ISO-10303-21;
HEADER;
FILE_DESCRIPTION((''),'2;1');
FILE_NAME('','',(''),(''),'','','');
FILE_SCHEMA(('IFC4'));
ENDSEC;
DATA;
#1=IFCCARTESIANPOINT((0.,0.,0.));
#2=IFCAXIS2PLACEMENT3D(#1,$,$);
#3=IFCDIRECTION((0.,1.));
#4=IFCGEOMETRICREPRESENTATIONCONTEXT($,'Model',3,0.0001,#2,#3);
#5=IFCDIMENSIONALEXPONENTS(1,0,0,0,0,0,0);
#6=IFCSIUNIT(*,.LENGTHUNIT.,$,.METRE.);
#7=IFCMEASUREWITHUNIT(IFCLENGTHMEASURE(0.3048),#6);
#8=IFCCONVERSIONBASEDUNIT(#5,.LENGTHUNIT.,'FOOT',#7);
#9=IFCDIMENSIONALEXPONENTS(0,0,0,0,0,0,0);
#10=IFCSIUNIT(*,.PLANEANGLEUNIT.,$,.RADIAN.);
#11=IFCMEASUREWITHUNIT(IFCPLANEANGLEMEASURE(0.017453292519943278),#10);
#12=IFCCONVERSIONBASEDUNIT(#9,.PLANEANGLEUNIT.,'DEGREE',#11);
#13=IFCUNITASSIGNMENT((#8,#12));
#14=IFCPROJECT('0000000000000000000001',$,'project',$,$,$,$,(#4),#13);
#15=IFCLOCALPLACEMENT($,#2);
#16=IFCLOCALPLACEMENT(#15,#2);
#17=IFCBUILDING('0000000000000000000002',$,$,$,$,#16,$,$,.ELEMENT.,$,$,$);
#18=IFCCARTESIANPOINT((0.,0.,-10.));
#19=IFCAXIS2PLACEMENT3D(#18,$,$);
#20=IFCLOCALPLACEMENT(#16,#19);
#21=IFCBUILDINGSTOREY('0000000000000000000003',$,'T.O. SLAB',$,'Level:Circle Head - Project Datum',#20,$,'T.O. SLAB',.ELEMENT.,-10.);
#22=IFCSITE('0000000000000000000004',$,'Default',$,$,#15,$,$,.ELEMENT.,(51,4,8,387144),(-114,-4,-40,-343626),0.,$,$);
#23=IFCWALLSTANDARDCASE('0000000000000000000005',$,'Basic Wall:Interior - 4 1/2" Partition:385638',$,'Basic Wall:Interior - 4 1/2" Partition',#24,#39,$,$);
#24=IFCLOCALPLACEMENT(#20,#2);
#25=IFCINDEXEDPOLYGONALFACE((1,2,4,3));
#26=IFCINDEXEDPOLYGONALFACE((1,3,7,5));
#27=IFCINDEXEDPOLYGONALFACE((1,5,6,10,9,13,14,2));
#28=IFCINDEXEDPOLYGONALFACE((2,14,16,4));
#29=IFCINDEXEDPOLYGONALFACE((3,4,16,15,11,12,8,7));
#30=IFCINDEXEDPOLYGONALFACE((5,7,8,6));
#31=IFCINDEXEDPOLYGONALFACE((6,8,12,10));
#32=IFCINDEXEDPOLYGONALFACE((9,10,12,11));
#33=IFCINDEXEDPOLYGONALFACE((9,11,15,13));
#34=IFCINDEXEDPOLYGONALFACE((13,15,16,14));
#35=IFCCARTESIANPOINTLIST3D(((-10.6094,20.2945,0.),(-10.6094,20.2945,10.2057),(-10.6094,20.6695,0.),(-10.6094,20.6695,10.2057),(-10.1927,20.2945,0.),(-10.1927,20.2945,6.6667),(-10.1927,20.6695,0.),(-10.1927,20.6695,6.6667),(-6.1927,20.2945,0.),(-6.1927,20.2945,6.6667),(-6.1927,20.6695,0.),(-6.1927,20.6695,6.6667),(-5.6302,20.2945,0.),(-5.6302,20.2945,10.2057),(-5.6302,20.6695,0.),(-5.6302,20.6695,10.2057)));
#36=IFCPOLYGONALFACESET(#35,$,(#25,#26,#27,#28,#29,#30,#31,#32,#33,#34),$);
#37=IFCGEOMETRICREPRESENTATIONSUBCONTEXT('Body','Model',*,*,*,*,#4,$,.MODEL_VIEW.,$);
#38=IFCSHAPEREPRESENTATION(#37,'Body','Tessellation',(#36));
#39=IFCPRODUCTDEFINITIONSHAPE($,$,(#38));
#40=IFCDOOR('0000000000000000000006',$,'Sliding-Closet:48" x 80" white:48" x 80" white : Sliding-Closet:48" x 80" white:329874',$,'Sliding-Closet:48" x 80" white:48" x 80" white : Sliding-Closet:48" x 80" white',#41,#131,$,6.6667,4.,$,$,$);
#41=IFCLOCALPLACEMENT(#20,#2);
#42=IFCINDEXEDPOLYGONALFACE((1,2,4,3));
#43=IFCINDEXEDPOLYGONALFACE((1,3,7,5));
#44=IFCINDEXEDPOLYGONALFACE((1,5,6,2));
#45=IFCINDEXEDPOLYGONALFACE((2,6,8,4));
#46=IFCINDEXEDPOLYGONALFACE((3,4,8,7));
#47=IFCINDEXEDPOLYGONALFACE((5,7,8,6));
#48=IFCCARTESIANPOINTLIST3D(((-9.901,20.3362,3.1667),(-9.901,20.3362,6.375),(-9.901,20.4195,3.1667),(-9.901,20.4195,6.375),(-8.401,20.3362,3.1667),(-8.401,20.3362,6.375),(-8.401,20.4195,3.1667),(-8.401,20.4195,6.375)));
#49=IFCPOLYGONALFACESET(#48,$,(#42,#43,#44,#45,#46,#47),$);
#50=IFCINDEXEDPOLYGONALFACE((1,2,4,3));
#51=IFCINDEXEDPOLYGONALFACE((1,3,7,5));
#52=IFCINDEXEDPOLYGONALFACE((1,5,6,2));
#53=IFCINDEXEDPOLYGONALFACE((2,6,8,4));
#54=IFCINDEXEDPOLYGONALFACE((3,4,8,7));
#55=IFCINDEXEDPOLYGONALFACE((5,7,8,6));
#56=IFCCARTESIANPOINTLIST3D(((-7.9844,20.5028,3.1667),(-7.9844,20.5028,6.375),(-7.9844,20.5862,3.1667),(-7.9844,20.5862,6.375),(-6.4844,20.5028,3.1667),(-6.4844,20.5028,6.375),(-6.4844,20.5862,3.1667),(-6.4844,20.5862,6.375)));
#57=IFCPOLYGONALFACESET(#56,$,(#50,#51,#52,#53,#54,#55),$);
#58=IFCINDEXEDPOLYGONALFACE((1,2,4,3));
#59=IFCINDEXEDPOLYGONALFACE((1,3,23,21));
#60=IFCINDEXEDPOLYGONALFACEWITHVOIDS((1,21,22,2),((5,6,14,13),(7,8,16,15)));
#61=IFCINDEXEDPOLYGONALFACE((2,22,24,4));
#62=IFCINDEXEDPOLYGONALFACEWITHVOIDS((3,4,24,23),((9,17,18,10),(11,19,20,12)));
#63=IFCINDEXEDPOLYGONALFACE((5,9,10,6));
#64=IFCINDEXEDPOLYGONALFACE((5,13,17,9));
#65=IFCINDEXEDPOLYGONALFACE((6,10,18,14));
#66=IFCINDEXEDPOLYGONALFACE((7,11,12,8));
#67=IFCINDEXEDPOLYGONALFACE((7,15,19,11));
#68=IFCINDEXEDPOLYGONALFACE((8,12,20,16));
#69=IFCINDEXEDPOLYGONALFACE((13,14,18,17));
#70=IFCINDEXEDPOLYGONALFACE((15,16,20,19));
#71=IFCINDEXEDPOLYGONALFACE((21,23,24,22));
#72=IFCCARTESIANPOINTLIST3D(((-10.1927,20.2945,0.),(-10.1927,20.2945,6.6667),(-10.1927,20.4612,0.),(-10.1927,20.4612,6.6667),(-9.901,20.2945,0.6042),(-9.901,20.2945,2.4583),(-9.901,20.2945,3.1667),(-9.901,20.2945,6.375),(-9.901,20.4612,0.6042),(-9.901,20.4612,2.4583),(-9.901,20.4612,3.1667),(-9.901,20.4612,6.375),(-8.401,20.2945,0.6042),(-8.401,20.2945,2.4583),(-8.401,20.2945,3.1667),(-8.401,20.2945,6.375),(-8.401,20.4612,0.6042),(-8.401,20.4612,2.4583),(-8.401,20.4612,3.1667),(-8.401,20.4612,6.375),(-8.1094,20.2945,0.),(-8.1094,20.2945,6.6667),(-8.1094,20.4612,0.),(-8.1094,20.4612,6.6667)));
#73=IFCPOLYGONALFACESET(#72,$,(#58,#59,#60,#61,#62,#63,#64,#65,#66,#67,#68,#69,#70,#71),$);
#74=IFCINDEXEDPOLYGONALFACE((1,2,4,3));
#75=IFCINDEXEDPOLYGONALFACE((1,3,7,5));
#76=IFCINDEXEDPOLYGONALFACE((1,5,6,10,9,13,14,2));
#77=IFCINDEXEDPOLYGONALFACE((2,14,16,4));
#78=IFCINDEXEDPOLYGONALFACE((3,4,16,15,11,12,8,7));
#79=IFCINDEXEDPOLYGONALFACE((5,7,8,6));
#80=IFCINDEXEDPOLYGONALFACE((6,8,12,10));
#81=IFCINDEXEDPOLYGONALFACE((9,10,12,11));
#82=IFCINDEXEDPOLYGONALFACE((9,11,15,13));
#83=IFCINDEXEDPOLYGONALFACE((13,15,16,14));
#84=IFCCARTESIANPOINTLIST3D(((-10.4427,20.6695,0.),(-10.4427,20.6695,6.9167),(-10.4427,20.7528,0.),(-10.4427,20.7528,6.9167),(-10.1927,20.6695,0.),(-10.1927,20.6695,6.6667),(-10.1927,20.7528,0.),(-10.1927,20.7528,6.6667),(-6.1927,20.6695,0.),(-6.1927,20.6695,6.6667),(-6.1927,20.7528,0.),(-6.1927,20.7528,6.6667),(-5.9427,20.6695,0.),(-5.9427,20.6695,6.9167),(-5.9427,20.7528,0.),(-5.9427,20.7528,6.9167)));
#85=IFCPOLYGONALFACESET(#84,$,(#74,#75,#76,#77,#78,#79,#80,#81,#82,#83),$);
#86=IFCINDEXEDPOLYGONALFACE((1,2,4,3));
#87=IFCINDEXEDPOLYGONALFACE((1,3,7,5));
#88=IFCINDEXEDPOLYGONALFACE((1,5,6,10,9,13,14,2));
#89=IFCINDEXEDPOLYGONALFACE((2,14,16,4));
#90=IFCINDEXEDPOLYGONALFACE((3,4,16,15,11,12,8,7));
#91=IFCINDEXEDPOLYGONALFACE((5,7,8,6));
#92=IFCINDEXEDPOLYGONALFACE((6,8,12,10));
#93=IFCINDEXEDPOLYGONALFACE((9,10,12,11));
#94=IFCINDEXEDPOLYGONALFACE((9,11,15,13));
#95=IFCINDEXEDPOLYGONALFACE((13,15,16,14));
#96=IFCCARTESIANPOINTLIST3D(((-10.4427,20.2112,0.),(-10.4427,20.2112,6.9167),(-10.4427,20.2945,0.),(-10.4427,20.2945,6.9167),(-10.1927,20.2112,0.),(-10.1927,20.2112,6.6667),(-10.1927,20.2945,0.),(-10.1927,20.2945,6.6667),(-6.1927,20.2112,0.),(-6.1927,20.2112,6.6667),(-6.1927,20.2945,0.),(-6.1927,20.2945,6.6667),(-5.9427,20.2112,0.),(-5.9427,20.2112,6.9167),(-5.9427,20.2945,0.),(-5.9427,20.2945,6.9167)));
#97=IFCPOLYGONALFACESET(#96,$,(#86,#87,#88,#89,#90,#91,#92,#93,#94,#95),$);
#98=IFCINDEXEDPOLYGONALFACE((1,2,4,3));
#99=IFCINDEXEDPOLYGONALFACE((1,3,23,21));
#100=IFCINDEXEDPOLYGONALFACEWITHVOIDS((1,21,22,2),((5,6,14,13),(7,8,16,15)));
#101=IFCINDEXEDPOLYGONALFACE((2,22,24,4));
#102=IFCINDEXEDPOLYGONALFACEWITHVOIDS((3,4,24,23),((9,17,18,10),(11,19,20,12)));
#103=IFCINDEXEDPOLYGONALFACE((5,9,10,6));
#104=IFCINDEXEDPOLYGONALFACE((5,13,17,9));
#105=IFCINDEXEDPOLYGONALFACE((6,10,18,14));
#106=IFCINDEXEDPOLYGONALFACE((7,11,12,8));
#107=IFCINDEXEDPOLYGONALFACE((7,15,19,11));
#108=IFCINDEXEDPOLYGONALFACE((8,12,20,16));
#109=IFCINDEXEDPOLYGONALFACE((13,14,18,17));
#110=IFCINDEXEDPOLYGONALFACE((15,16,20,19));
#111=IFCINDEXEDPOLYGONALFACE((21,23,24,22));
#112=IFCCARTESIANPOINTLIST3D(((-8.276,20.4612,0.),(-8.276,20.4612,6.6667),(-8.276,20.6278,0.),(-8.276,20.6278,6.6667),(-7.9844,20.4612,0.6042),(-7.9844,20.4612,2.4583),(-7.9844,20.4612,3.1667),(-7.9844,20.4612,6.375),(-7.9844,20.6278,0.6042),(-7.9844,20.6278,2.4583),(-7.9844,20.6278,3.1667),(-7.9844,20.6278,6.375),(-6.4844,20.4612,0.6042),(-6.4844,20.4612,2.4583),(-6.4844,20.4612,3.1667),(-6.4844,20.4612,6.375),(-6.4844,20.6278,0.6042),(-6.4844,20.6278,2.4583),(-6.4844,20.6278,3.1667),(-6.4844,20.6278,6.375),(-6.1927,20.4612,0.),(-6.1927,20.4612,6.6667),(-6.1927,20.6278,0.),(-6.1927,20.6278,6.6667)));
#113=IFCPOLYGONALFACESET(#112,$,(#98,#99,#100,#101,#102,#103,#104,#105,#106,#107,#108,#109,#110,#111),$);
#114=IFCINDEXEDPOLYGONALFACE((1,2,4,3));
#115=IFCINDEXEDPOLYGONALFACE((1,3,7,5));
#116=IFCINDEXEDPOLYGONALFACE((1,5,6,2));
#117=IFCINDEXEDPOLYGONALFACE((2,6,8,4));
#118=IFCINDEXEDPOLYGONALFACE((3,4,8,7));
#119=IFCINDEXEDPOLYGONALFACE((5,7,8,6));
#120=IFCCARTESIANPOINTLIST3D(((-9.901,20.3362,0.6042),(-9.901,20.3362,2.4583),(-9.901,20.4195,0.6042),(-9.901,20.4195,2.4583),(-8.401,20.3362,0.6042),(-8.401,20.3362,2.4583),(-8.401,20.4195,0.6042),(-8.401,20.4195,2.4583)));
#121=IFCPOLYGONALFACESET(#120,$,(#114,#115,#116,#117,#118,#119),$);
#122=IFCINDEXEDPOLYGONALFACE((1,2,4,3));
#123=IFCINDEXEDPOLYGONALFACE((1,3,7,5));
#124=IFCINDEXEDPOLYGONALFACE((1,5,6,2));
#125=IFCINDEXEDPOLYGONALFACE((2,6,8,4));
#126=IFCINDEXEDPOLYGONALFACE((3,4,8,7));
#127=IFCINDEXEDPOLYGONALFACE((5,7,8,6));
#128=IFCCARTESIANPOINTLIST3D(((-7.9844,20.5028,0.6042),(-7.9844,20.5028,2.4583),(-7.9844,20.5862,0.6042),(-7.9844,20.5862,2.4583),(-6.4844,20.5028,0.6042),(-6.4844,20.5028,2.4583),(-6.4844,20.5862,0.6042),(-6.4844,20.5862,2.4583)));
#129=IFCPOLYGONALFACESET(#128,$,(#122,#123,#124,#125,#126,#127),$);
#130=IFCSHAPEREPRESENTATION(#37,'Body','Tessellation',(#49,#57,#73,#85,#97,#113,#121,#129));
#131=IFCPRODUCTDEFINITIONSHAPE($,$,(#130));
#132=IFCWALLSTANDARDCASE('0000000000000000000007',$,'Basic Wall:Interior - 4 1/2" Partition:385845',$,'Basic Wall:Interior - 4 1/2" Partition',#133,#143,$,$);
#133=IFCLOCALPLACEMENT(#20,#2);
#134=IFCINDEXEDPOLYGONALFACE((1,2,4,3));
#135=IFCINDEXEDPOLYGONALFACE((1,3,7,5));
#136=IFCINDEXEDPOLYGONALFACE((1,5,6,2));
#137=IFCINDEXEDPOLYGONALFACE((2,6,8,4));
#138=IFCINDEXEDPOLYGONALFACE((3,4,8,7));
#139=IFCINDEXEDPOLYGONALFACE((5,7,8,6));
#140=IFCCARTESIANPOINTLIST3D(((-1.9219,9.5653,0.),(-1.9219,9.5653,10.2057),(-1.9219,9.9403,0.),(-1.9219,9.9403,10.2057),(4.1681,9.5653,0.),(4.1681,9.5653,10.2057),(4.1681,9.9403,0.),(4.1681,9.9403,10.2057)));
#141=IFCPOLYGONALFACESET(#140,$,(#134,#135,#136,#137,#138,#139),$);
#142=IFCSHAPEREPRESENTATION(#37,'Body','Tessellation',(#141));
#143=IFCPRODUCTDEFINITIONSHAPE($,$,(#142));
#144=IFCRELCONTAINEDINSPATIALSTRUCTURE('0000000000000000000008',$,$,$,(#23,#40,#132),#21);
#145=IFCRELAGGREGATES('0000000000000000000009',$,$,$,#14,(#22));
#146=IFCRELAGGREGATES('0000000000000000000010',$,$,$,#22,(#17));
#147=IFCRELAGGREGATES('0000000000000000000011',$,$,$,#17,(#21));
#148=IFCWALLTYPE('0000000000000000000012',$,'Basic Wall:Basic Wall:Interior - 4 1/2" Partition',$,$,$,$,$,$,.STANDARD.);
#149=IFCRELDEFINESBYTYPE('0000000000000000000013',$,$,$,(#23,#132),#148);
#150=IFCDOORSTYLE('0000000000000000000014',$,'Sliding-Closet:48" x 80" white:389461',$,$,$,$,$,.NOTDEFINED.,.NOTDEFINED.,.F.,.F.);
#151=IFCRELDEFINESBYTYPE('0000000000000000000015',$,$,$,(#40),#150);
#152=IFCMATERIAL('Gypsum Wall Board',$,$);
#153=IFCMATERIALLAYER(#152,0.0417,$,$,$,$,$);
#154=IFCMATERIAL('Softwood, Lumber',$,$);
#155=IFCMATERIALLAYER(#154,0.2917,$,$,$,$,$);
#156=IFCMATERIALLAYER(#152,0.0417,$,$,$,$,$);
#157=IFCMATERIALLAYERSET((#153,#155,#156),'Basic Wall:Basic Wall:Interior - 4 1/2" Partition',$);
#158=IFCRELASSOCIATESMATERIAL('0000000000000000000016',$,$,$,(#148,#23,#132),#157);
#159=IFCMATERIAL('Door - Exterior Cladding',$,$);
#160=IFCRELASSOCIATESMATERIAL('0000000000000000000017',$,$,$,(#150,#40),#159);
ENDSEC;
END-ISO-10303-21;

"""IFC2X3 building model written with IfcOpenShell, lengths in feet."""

from ifc_helpers import new_model, entity, si_unit, converted_unit, direction, frame, frame_2d, origin, origin_2d_with_axis, place, context, subcontext, project, spatial, polyline, rectangle, outline, extrude, source, transform, mapped, material, layer, layer_set, layer_usage, type_object, type_shapes, element, fill, save


model = new_model("IFC2X3")

# Units and contexts
model_context = context("Model", 3, precision=0.0001, world=origin(), true_north=direction((0.0, 1.0)))
body_context = subcontext(model_context, "Body", "Model", "MODEL_VIEW")
ifc_project = project(units=[converted_unit("LENGTHUNIT", "FOOT", entity("IfcLengthMeasure", 0.3048), si_unit("LENGTHUNIT", "METRE"), dimensions=[1, 0, 0, 0, 0, 0, 0]), converted_unit("PLANEANGLEUNIT", "DEGREE", entity("IfcPlaneAngleMeasure", 0.017453292519943278), si_unit("PLANEANGLEUNIT", "RADIAN"), dimensions=[0, 0, 0, 0, 0, 0, 0])], contexts=[model_context])

# Site, building, storey
site_placement = place(None, origin())
site = spatial("IfcSite", under=ifc_project, at=site_placement, Name="Default", CompositionType="ELEMENT", RefLatitude=(51, 4, 8, 387144), RefLongitude=(-114, -4, -40, -343626), RefElevation=0.0)
building_placement = place(site_placement, origin())
building = spatial("IfcBuilding", under=site, at=building_placement, CompositionType="ELEMENT")
storey_placement = place(building_placement, frame((0.0, 0.0, -10.0)))
storey = spatial("IfcBuildingStorey", under=building, at=storey_placement, Name="T.O. SLAB", ObjectType="Level:Circle Head - Project Datum", LongName="T.O. SLAB", CompositionType="ELEMENT", Elevation=-10.0)

# Shared definitions
ifc_material_1 = material(Name="Gypsum Wall Board")
ifc_layer_1 = layer(ifc_material_1, 0.0417)
ifc_material_2 = material(Name="Softwood, Lumber")
ifc_layer_2 = layer(ifc_material_2, 0.2917)
ifc_layer_3 = layer(ifc_material_1, 0.0417)
ifc_layer_set_1 = layer_set([ifc_layer_1, ifc_layer_2, ifc_layer_3], Name="Basic Wall:Basic Wall:Interior - 4 1/2\" Partition")
wall_type_1 = type_object("IfcWallType", Name="Basic Wall:Basic Wall:Interior - 4 1/2\" Partition", PredefinedType="STANDARD", material=ifc_layer_set_1)
ifc_material_3 = material(Name="Door - Exterior Cladding")

# Wall, opening, door
ifc_layer_usage_1 = layer_usage(ifc_layer_set_1, "AXIS2", "NEGATIVE", 0.1875)
wall_1_placement = place(storey_placement, frame((-10.6094, 20.482, 0.0)))
wall_1 = element("IfcWallStandardCase", 1, at=wall_1_placement, inside=storey, type_object=wall_type_1, material=ifc_layer_usage_1, Name="Basic Wall:Interior - 4 1/2\" Partition:385638", ObjectType="Basic Wall:Interior - 4 1/2\" Partition", context=body_context, shape_type="SweptSolid", body=[
    extrude(rectangle(XDim=4.9792, YDim=0.375, at=frame_2d((2.4896, 0.0), x_axis=(1.0, 0.0))), origin(), (0.0, 0.0, 1.0), 10.2057),
])
opening_1_placement = place(wall_1_placement, frame((10.6094, -20.482, 0.0)))
opening_1 = element("IfcOpeningElement", 2, at=opening_1_placement, cuts=wall_1, ObjectType="Opening", context=body_context, shape_type="SweptSolid", body=[
    extrude(rectangle(XDim=6.6667, YDim=4.0, at=origin_2d_with_axis()), frame((-8.1927, 20.2908, 3.3333), z_axis=(0.0, 1.0, 0.0), x_axis=(0.0, 0.0, 1.0)), (0.0, 0.0, 1.0), 0.3825),
])
door_style_1 = type_object("IfcDoorStyle", Name="Sliding-Closet:48\" x 80\" white:389461", ConstructionType="NOTDEFINED", OperationType="NOTDEFINED", ParameterTakesPrecedence=False, Sizeable=False, material=ifc_material_3)
shared_shape_1 = source(origin(), body_context, "Body", "SweptSolid", [
    extrude(rectangle(XDim=0.0833, YDim=1.5, at=origin_2d_with_axis()), frame((2.9583, 0.2954, 3.1667), z_axis=(0.0, 0.0, 1.0), x_axis=(0.0, 1.0, 0.0)), (0.0, 0.0, 1.0), 3.2083),
    extrude(rectangle(XDim=0.0833, YDim=1.5, at=origin_2d_with_axis()), frame((1.0417, 0.1287, 3.1667), z_axis=(0.0, 0.0, 1.0), x_axis=(0.0, -1.0, 0.0)), (0.0, 0.0, 1.0), 3.2083),
    extrude(outline(polyline([(-3.3333, -1.0417), (3.3333, -1.0417), (3.3333, 1.0417), (-3.3333, 1.0417), (-3.3333, -1.0417)]), holes=[polyline([(-0.1667, -0.75), (-0.1667, 0.75), (3.0417, 0.75), (3.0417, -0.75), (-0.1667, -0.75)]), polyline([(-2.7292, -0.75), (-2.7292, 0.75), (-0.875, 0.75), (-0.875, -0.75), (-2.7292, -0.75)])]), frame((2.9583, 0.2121, 3.3333), z_axis=(0.0, 1.0, 0.0), x_axis=(0.0, 0.0, 1.0)), (0.0, 0.0, 1.0), 0.1667),
    extrude(outline(polyline([(-3.5208, -2.25), (3.3958, -2.25), (3.3958, -2.0), (-3.2708, -2.0), (-3.2708, 2.0), (3.3958, 2.0), (3.3958, 2.25), (-3.5208, 2.25), (-3.5208, -2.25)])), frame((2.0, -0.0796, 3.3958), z_axis=(0.0, 1.0, 0.0), x_axis=(0.0, 0.0, -1.0)), (0.0, 0.0, 1.0), 0.0833),
    extrude(outline(polyline([(2.0, -3.3958), (2.25, -3.3958), (2.25, 3.5208), (-2.25, 3.5208), (-2.25, -3.3958), (-2.0, -3.3958), (-2.0, 3.2708), (2.0, 3.2708), (2.0, -3.3958)])), frame((2.0, 0.3788, 3.3958), z_axis=(0.0, 1.0, 0.0), x_axis=(-1.0, 0.0, 0.0)), (0.0, 0.0, 1.0), 0.0833),
    extrude(outline(polyline([(-1.0417, -3.3333), (1.0417, -3.3333), (1.0417, 3.3333), (-1.0417, 3.3333), (-1.0417, -3.3333)]), holes=[polyline([(-0.75, 0.875), (-0.75, 2.7292), (0.75, 2.7292), (0.75, 0.875), (-0.75, 0.875)]), polyline([(-0.75, -3.0417), (-0.75, 0.1667), (0.75, 0.1667), (0.75, -3.0417), (-0.75, -3.0417)])]), frame((1.0417, 0.0454, 3.3333), z_axis=(0.0, 1.0, 0.0), x_axis=(1.0, 0.0, 0.0)), (0.0, 0.0, 1.0), 0.1667),
    extrude(rectangle(XDim=0.0833, YDim=1.5, at=origin_2d_with_axis()), frame((2.9583, 0.2954, 0.6042), z_axis=(0.0, 0.0, 1.0), x_axis=(0.0, 1.0, 0.0)), (0.0, 0.0, 1.0), 1.8542),
    extrude(rectangle(XDim=0.0833, YDim=1.5, at=origin_2d_with_axis()), frame((1.0417, 0.1287, 0.6042), z_axis=(0.0, 0.0, 1.0), x_axis=(0.0, -1.0, 0.0)), (0.0, 0.0, 1.0), 1.8542),
])
type_shapes(door_style_1, [shared_shape_1])
door_1_placement = place(opening_1_placement, frame((-6.1927, 20.6733, 0.0), z_axis=(0.0, 0.0, 1.0), x_axis=(-1.0, 0.0, 0.0)))
door_1 = element("IfcDoor", 3, at=door_1_placement, inside=storey, type_object=door_style_1, material=ifc_material_3, Name="Sliding-Closet:48\" x 80\" white:48\" x 80\" white : Sliding-Closet:48\" x 80\" white:329874", ObjectType="Sliding-Closet:48\" x 80\" white:48\" x 80\" white : Sliding-Closet:48\" x 80\" white", OverallHeight=6.6667, OverallWidth=4.0, context=body_context, shape_type="MappedRepresentation", body=[
    mapped(shared_shape_1, transform((0.0, 0.0, 0.0), scale=1.0)),
])
fill(opening_1, door_1)

# Wall
ifc_layer_usage_2 = layer_usage(ifc_layer_set_1, "AXIS2", "NEGATIVE", 0.1875)
wall_2_placement = place(storey_placement, frame((-1.9219, 9.7528, 0.0)))
element("IfcWallStandardCase", 4, at=wall_2_placement, inside=storey, type_object=wall_type_1, material=ifc_layer_usage_2, Name="Basic Wall:Interior - 4 1/2\" Partition:385845", ObjectType="Basic Wall:Interior - 4 1/2\" Partition", context=body_context, shape_type="SweptSolid", body=[
    extrude(rectangle(XDim=6.09, YDim=0.375, at=frame_2d((3.045, 0.0), x_axis=(-1.0, 0.0))), origin(), (0.0, 0.0, 1.0), 10.2057),
])

save(model, "model.ifc")
